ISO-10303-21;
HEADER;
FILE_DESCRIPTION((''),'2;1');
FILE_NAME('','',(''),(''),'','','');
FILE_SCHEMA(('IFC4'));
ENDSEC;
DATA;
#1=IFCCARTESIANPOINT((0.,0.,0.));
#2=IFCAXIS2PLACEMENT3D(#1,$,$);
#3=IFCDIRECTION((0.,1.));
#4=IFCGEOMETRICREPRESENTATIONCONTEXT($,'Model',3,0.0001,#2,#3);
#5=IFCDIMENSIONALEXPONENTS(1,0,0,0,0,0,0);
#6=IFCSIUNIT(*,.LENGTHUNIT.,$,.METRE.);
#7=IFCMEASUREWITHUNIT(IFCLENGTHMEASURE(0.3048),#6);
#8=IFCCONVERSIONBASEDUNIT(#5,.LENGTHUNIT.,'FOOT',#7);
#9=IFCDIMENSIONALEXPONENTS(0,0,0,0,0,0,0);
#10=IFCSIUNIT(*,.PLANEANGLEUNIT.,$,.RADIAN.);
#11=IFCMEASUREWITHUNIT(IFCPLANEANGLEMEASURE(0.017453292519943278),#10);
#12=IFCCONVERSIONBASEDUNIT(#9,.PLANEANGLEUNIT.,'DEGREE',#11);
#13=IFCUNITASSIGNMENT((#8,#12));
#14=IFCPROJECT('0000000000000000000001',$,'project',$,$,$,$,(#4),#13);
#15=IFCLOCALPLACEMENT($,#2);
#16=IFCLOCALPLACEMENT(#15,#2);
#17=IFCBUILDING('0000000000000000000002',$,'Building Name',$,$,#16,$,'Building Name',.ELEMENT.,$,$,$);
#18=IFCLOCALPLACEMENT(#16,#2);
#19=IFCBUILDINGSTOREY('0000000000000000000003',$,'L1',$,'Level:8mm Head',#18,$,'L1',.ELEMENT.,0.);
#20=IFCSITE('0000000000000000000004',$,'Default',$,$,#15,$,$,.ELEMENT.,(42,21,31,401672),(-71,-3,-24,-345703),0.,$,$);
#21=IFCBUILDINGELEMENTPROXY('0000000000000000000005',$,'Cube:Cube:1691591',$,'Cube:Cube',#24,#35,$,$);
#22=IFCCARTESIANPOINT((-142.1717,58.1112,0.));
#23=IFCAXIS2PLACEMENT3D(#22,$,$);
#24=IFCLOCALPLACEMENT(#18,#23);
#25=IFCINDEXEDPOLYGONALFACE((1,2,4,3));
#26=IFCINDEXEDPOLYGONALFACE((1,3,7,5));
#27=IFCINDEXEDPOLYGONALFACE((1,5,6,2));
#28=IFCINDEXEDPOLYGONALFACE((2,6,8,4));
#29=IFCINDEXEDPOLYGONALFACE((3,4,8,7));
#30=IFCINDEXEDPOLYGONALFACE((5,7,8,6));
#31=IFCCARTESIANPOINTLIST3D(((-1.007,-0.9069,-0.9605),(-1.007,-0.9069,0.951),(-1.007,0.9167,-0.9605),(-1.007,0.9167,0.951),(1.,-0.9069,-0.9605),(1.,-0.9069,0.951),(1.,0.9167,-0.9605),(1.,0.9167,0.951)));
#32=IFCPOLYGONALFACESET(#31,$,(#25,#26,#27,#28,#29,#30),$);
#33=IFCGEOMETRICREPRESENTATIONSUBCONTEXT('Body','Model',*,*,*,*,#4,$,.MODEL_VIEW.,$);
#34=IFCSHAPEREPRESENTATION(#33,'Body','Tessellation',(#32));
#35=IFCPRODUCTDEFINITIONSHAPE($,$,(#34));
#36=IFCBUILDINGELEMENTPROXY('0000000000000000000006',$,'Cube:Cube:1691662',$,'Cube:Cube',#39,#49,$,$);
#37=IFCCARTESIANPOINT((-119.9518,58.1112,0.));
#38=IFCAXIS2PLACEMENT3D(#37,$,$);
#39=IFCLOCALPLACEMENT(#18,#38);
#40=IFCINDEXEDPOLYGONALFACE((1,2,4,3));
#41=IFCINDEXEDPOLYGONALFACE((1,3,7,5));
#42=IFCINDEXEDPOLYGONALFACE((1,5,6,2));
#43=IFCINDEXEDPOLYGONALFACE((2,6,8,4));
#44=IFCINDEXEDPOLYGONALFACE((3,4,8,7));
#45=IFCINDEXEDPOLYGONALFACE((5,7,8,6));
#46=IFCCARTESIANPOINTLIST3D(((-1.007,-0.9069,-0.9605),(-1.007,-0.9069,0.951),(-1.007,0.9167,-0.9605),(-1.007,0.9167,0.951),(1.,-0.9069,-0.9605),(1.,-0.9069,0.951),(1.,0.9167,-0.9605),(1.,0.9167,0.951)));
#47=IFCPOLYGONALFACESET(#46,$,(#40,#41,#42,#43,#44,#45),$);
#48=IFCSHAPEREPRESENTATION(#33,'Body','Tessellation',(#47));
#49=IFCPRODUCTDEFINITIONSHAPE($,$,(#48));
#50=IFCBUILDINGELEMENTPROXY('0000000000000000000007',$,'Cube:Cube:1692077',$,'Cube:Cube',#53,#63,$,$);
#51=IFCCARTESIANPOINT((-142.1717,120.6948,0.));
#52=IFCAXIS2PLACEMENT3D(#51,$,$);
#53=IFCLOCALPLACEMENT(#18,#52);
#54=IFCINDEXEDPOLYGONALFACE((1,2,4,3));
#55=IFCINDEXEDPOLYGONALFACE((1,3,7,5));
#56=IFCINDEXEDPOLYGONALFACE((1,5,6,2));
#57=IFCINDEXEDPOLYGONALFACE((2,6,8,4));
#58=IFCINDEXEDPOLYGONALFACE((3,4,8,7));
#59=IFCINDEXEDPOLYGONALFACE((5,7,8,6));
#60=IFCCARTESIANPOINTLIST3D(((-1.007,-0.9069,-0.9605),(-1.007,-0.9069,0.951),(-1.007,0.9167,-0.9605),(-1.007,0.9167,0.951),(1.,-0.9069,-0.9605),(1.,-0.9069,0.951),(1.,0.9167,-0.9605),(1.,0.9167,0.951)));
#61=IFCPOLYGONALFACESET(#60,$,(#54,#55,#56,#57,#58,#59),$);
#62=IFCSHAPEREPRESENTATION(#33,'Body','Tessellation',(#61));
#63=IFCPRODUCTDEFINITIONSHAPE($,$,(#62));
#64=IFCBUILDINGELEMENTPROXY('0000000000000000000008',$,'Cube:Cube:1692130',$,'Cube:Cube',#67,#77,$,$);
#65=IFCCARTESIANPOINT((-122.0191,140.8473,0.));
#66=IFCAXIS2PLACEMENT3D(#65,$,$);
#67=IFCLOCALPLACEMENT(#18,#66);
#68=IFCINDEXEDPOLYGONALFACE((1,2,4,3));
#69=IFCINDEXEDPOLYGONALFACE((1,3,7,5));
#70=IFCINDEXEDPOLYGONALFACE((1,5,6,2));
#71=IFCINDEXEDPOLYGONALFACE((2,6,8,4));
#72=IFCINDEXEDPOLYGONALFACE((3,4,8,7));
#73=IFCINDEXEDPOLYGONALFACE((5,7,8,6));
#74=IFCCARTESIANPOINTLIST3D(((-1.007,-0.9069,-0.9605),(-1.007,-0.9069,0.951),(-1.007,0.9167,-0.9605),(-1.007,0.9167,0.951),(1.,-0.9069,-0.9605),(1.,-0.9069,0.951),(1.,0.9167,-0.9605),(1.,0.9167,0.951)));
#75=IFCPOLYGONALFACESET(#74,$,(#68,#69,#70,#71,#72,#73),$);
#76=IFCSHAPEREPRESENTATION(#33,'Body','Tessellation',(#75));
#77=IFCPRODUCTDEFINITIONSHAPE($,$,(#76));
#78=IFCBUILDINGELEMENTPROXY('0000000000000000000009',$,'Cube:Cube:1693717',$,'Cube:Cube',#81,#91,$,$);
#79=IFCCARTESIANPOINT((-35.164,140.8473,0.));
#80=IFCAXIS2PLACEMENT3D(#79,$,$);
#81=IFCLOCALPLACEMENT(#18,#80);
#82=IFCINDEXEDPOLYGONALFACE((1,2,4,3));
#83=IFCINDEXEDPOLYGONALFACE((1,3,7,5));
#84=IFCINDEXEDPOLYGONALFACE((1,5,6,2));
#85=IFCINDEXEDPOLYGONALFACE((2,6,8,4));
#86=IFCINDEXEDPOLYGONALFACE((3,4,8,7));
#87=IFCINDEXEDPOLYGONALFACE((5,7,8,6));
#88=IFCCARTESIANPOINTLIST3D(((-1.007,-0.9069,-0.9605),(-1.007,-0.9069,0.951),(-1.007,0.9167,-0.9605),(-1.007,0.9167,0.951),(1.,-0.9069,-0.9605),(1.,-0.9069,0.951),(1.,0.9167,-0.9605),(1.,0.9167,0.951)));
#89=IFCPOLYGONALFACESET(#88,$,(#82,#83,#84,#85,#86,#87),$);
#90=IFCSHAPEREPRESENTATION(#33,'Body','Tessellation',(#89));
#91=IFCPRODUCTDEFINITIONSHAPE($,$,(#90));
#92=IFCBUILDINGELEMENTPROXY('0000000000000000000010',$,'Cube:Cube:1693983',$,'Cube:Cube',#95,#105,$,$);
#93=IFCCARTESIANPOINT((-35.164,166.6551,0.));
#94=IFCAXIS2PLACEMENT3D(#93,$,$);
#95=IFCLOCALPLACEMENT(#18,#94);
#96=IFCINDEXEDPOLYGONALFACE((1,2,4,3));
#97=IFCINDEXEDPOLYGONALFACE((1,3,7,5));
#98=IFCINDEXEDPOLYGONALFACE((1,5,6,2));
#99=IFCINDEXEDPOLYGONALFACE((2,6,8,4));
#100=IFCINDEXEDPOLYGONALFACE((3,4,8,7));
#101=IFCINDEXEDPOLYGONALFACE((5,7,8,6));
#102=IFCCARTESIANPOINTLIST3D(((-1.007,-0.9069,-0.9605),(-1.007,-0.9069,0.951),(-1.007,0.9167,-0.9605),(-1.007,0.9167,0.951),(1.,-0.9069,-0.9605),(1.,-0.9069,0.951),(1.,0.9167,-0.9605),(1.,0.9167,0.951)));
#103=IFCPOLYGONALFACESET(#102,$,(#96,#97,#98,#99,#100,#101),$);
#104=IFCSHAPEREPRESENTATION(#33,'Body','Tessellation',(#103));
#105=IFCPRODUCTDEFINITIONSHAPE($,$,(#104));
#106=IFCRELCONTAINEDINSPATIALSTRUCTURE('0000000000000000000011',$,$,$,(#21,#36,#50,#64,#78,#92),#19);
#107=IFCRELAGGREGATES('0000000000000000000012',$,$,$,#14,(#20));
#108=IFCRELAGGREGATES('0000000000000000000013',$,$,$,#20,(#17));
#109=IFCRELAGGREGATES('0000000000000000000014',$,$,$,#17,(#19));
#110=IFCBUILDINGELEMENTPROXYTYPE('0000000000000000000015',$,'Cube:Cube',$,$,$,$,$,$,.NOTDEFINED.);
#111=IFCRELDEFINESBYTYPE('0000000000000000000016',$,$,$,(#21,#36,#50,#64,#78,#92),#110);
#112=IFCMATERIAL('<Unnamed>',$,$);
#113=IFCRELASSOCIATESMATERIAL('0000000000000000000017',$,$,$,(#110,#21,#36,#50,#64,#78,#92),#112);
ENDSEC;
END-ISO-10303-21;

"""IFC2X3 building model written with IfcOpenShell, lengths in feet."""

from ifc_helpers import new_model, entity, si_unit, converted_unit, direction, frame, frame_2d, origin, place, context, subcontext, project, spatial, rectangle, extrude, source, transform, mapped, material, type_object, type_shapes, element, save


model = new_model("IFC2X3")

# Units and contexts
model_context = context("Model", 3, precision=0.0001, world=origin(), true_north=direction((0.0, 1.0)))
body_context = subcontext(model_context, "Body", "Model", "MODEL_VIEW")
ifc_project = project(units=[converted_unit("LENGTHUNIT", "FOOT", entity("IfcLengthMeasure", 0.3048), si_unit("LENGTHUNIT", "METRE"), dimensions=[1, 0, 0, 0, 0, 0, 0]), converted_unit("PLANEANGLEUNIT", "DEGREE", entity("IfcPlaneAngleMeasure", 0.017453292519943278), si_unit("PLANEANGLEUNIT", "RADIAN"), dimensions=[0, 0, 0, 0, 0, 0, 0])], contexts=[model_context])

# Site, building, storey
site_placement = place(None, origin())
site = spatial("IfcSite", under=ifc_project, at=site_placement, Name="Default", CompositionType="ELEMENT", RefLatitude=(42, 21, 31, 401672), RefLongitude=(-71, -3, -24, -345703), RefElevation=0.0)
building_placement = place(site_placement, origin())
building = spatial("IfcBuilding", under=site, at=building_placement, Name="Building Name", LongName="Building Name", CompositionType="ELEMENT")
storey_placement = place(building_placement, origin())
storey = spatial("IfcBuildingStorey", under=building, at=storey_placement, Name="L1", ObjectType="Level:8mm Head", LongName="L1", CompositionType="ELEMENT", Elevation=0.0)

# Building element proxies
ifc_material_1 = material(Name="<Unnamed>")
building_element_proxy_type = type_object("IfcBuildingElementProxyType", Name="Cube:Cube", PredefinedType="NOTDEFINED", material=ifc_material_1)
shared_shape = source(origin(), body_context, "Body", "SweptSolid", [
    extrude(rectangle(XDim=1.8235, YDim=2.007, at=frame_2d((0.0, 0.0), x_axis=(1.0, 0.0))), frame((-0.0035, 0.0049, -0.9605), z_axis=(0.0, 0.0, 1.0), x_axis=(0.0, 1.0, 0.0)), (0.0, 0.0, 1.0), 1.9115),
])
type_shapes(building_element_proxy_type, [shared_shape])
for number, where, name in (
    (1, (-142.1717, 58.1112, 0.0), "Cube:Cube:1691591"),
    (2, (-119.9518, 58.1112, 0.0), "Cube:Cube:1691662"),
    (3, (-142.1717, 120.6948, 0.0), "Cube:Cube:1692077"),
    (4, (-122.0191, 140.8473, 0.0), "Cube:Cube:1692130"),
    (5, (-35.164, 140.8473, 0.0), "Cube:Cube:1693717"),
    (6, (-35.164, 166.6551, 0.0), "Cube:Cube:1693983"),
):
    element("IfcBuildingElementProxy", number, at=place(storey_placement, frame(where)), inside=storey, type_object=building_element_proxy_type, material=ifc_material_1, Name=name, ObjectType="Cube:Cube", context=body_context, shape_type="MappedRepresentation", body=[
        mapped(shared_shape, transform((0.0, 0.0, 0.0), scale=1.0)),
    ])

save(model, "model.ifc")
